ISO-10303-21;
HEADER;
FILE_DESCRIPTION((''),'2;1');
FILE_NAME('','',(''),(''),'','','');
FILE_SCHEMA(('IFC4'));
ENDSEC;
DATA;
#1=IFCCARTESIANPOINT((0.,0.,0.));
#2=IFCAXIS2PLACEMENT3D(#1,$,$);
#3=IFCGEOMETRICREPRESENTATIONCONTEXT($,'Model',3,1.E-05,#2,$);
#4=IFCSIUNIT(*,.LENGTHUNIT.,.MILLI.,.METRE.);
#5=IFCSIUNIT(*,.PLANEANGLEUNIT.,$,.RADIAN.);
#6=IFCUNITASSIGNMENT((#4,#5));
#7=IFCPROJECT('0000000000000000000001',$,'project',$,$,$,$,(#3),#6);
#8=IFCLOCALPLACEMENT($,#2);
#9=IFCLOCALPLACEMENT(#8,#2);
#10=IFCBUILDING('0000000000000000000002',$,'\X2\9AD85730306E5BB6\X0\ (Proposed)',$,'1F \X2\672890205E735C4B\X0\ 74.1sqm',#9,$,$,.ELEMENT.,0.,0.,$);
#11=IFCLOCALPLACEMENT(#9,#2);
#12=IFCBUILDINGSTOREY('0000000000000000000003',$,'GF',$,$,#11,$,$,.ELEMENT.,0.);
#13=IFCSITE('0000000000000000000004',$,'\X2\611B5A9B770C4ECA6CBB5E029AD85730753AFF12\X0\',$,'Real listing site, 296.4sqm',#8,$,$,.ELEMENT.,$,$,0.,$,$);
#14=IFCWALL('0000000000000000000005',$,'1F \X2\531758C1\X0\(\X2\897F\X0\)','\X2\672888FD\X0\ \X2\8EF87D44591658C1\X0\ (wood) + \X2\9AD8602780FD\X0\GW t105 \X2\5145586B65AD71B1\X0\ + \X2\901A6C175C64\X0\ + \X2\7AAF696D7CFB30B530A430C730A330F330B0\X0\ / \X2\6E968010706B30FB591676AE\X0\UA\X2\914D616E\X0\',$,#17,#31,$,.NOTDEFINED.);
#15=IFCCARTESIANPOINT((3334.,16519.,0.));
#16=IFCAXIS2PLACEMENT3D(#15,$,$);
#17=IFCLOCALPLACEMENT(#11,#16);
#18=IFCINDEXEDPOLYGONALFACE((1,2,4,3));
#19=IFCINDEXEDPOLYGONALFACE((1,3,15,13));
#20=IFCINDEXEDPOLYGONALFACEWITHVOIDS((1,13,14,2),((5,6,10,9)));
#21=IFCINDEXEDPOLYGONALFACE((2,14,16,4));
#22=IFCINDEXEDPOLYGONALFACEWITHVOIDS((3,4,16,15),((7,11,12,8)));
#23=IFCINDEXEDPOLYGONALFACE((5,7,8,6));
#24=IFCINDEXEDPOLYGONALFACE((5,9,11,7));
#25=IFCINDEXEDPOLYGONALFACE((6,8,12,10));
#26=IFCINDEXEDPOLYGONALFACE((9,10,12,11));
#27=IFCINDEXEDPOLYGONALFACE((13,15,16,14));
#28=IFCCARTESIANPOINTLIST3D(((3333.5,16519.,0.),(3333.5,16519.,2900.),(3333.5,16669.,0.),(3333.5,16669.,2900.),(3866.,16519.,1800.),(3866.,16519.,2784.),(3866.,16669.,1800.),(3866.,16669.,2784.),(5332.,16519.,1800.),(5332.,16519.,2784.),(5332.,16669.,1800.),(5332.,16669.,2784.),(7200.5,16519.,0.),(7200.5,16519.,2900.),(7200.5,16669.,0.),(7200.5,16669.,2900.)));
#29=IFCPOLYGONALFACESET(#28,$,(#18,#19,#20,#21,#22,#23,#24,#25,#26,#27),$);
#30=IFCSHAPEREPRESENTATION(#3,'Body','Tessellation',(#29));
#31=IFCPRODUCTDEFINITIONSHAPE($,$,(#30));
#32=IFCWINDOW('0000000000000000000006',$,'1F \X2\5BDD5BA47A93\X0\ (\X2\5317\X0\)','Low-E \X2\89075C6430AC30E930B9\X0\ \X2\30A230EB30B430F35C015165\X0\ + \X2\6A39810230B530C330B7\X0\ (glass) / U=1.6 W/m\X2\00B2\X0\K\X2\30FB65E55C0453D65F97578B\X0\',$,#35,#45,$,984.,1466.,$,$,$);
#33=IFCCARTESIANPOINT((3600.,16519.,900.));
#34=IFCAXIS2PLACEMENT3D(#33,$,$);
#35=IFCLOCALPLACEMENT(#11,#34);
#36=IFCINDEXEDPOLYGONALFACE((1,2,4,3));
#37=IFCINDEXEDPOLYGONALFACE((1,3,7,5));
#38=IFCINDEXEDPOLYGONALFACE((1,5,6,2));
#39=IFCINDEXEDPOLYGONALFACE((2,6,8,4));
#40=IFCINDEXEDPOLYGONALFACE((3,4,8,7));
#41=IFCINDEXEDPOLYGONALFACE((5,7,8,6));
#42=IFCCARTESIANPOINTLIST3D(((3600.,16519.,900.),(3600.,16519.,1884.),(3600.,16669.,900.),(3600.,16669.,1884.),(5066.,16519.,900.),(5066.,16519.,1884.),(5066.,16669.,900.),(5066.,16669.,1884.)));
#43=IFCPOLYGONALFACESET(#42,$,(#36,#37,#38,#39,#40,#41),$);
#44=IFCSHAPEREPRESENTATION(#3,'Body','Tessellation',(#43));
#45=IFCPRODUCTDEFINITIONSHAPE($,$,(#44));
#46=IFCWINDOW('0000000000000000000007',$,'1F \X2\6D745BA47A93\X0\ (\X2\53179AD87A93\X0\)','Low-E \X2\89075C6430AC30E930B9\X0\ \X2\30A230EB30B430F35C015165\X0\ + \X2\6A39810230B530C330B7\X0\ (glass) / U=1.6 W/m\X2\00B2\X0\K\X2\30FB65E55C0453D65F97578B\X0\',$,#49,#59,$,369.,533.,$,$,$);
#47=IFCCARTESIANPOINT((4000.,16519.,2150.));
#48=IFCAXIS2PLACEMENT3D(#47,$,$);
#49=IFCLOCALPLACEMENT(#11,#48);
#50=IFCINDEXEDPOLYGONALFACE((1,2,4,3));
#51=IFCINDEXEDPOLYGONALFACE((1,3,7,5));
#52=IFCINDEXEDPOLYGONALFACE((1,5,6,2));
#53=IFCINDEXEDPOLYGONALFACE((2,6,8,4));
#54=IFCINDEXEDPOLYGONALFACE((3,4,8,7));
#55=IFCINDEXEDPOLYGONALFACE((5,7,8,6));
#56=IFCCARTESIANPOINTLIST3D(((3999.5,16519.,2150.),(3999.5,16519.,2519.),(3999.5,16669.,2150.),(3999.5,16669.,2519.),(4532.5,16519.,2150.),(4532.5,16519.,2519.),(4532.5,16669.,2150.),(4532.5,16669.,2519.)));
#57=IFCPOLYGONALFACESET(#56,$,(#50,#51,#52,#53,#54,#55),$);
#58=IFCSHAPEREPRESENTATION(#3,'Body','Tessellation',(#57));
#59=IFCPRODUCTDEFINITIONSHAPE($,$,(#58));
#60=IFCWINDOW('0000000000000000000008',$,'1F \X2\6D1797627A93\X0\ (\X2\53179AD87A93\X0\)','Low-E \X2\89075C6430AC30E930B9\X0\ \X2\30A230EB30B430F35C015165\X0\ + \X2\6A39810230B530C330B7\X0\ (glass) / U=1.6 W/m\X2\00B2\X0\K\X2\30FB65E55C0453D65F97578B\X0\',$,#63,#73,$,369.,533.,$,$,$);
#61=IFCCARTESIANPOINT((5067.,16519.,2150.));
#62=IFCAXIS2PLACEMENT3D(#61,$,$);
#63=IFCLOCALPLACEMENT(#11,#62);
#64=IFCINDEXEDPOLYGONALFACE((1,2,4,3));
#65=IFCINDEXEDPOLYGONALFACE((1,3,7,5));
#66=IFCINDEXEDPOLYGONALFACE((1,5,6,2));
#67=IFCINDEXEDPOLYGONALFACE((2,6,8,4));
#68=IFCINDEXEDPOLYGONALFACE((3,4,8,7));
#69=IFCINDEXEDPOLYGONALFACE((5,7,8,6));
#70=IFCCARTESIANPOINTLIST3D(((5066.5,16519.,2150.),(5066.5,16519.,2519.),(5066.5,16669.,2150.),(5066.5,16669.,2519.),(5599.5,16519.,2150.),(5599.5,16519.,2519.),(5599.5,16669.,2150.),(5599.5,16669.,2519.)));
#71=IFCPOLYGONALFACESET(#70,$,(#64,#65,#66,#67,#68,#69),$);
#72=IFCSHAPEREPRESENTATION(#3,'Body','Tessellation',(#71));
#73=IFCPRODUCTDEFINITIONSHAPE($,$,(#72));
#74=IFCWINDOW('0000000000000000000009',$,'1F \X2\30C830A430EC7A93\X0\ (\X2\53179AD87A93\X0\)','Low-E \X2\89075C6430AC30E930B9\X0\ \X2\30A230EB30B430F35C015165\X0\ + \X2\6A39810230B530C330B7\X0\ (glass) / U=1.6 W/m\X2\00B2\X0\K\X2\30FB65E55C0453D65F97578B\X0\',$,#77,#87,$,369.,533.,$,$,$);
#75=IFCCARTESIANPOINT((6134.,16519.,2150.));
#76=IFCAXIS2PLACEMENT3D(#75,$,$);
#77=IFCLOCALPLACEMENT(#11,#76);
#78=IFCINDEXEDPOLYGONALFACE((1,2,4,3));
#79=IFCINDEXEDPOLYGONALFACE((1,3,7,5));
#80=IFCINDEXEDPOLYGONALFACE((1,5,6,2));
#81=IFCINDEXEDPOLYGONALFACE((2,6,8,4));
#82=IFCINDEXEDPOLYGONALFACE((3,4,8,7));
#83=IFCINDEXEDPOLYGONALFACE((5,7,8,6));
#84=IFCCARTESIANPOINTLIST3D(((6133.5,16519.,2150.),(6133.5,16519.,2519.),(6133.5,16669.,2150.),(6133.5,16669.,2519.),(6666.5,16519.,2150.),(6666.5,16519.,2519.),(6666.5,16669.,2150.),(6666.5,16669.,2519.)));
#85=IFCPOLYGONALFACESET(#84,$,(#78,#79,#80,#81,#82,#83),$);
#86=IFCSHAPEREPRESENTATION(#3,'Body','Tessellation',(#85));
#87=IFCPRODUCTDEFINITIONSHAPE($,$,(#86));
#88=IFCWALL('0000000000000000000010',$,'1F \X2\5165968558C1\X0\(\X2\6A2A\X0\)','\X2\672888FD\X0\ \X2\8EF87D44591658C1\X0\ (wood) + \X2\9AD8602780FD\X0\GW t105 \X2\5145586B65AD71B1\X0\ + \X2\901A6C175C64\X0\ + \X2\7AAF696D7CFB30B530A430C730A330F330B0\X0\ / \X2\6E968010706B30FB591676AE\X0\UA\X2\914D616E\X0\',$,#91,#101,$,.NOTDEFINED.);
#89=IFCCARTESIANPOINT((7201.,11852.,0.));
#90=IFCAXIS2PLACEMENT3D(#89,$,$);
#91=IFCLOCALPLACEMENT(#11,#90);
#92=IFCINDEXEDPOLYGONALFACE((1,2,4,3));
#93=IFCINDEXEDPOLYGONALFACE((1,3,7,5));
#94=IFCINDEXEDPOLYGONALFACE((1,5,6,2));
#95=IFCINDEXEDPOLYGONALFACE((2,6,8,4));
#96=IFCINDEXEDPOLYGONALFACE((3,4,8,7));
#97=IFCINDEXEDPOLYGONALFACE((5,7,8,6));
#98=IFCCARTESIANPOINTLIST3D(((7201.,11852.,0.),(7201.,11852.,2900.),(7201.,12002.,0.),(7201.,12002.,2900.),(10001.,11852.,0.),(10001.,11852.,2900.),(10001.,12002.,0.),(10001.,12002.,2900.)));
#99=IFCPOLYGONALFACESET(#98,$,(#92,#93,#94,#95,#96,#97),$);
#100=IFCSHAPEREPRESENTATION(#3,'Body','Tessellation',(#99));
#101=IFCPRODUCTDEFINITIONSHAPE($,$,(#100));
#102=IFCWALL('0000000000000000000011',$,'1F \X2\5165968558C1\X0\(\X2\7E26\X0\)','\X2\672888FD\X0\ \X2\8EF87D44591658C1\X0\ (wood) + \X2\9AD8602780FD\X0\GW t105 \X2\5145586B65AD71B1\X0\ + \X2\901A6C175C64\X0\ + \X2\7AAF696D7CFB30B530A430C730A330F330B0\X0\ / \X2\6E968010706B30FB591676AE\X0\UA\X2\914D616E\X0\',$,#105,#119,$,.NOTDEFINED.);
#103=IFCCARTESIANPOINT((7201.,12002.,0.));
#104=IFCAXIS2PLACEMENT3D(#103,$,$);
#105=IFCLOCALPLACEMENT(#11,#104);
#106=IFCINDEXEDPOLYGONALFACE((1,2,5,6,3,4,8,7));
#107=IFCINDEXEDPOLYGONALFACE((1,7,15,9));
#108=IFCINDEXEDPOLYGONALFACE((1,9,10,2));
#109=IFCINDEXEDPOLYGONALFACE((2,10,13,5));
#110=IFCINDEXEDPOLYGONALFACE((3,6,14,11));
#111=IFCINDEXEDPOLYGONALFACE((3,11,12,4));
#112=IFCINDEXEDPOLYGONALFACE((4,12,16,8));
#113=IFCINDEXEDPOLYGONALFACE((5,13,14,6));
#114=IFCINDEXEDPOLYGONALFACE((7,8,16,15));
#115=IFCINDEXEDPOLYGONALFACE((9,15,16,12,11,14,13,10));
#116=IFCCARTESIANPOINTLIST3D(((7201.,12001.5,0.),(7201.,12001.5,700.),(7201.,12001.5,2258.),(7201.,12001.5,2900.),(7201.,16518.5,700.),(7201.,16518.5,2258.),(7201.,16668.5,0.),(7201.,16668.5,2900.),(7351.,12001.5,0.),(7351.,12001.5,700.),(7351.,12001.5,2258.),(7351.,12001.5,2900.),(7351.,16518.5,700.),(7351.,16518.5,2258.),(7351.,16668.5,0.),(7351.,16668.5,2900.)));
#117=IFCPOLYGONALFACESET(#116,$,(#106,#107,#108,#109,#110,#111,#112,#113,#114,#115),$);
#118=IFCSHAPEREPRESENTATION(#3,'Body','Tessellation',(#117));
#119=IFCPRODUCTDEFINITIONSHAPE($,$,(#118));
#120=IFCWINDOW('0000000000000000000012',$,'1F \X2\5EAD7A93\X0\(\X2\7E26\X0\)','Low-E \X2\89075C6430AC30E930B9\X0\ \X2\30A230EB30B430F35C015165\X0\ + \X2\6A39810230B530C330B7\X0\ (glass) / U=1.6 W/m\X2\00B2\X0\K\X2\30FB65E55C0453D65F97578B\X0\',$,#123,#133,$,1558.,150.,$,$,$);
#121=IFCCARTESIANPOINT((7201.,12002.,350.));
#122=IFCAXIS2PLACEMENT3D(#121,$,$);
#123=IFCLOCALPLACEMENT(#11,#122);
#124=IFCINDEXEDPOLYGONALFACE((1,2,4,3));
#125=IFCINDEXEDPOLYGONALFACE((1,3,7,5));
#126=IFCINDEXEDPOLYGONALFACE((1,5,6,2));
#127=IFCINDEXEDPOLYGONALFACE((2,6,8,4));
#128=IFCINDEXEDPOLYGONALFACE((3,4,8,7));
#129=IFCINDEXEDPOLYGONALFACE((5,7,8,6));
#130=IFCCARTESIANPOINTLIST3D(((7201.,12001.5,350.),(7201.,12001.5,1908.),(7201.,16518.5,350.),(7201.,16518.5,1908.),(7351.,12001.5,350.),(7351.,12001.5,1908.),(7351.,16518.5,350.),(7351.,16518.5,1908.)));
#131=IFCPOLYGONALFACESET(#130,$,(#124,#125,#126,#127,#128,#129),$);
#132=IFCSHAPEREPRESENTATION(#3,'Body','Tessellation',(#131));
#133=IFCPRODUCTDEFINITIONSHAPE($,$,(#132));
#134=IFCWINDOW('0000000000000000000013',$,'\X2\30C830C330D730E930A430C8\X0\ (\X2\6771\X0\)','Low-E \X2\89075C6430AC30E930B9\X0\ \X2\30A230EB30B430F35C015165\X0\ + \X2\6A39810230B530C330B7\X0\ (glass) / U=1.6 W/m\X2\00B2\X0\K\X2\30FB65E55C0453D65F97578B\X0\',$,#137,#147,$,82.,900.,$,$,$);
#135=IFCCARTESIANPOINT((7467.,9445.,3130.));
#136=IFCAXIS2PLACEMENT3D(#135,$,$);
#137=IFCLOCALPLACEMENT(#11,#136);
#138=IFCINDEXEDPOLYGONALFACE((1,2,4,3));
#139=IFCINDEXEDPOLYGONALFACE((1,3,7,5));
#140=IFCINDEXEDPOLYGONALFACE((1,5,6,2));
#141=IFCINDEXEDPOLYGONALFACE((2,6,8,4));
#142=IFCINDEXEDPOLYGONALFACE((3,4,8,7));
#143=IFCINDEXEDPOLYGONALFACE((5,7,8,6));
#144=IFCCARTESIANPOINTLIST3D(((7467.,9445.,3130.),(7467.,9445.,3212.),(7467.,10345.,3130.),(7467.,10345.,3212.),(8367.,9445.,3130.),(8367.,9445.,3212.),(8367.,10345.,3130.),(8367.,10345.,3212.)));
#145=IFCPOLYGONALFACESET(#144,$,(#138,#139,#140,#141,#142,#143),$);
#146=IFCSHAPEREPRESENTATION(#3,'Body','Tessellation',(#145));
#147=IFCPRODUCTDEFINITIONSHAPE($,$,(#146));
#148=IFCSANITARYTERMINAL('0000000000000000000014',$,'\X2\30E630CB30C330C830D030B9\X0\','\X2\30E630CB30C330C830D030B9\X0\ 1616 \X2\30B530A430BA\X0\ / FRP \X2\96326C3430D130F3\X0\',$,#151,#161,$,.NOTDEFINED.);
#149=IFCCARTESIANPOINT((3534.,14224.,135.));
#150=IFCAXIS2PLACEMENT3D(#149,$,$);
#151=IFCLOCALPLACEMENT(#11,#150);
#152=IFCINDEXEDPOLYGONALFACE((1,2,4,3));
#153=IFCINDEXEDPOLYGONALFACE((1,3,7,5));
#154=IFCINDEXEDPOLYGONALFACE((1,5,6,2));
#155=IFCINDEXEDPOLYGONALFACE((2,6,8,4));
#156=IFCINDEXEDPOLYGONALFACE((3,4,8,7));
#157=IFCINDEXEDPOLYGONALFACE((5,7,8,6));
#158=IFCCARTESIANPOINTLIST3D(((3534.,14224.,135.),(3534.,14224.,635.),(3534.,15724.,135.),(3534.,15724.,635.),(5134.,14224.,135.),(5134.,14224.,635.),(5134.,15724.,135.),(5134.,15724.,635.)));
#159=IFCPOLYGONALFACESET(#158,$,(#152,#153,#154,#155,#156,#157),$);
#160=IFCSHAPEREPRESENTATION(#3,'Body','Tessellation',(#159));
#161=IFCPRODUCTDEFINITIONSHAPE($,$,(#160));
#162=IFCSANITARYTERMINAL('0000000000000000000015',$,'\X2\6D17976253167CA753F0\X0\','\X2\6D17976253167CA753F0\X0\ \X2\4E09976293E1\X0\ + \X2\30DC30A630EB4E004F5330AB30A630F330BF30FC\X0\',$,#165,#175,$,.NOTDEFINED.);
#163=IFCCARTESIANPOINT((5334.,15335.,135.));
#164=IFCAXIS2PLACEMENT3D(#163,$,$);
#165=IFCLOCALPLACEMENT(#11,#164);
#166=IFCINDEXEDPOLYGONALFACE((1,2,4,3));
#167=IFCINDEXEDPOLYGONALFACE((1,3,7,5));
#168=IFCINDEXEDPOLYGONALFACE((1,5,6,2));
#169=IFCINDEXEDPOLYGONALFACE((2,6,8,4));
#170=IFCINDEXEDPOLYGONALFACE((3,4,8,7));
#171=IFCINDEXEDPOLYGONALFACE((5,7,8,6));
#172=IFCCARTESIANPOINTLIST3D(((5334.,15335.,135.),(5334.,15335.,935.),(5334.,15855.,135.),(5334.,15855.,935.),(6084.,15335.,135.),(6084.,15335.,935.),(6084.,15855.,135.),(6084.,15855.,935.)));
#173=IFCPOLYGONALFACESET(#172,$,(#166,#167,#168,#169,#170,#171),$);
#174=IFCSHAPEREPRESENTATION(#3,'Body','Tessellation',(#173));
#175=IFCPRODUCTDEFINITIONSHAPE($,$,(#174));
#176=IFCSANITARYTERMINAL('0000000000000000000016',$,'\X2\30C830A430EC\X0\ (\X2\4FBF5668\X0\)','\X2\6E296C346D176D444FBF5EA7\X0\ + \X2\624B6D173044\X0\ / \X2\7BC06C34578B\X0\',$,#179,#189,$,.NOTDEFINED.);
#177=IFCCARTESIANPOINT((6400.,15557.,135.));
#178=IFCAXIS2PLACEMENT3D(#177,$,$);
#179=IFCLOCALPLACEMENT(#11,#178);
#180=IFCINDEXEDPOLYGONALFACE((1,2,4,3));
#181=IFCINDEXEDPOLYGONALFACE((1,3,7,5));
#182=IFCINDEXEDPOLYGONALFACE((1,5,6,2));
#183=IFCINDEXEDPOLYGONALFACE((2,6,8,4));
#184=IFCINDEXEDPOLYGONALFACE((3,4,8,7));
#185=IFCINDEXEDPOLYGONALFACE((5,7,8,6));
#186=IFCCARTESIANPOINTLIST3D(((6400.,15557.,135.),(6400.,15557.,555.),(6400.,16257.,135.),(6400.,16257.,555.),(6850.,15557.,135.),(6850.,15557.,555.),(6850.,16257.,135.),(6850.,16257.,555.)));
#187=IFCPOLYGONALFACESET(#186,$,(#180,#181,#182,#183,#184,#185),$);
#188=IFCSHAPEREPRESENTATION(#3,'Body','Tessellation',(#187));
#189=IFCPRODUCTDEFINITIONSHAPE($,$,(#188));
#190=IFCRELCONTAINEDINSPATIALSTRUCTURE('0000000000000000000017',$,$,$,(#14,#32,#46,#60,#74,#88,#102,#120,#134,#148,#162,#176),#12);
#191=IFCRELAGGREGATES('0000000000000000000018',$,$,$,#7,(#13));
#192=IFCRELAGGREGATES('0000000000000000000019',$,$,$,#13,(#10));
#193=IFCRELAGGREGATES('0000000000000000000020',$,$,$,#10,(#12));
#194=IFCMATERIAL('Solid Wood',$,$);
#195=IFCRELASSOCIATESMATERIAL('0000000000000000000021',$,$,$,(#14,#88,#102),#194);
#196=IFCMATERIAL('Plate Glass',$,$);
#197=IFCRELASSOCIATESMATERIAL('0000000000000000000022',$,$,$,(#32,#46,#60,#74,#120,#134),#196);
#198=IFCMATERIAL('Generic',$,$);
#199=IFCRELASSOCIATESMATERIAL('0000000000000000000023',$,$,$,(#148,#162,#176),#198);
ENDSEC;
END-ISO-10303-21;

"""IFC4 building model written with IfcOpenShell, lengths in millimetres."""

from ifc_helpers import new_model, si_unit, frame, frame_2d, origin, place, context, project, spatial, rectangle, extrude, material, element, fill, save


model = new_model("IFC4")

# Units and contexts
model_context = context("Model", 3, precision=1e-05, world=origin())
ifc_project = project(units=[si_unit("LENGTHUNIT", "METRE", prefix="MILLI"), si_unit("PLANEANGLEUNIT", "RADIAN")], contexts=[model_context])

# Site, building, storey
site_placement = place(None, origin())
site = spatial("IfcSite", under=ifc_project, at=site_placement, Name="愛媛県今治市高地町２", ObjectType="Real listing site, 296.4sqm", CompositionType="ELEMENT", RefElevation=0.0)
building_placement = place(site_placement, origin())
building = spatial("IfcBuilding", under=site, at=building_placement, Name="高地の家 (Proposed)", ObjectType="1F 木造平屋 74.1sqm", CompositionType="ELEMENT", ElevationOfRefHeight=0.0, ElevationOfTerrain=0.0)
storey_placement = place(building_placement, origin())
storey = spatial("IfcBuildingStorey", under=building, at=storey_placement, Name="GF", CompositionType="ELEMENT", Elevation=0.0)

# Shared definitions
ifc_material_1 = material(Name="Solid Wood")

# Wall, openings, windows
wall_1_placement = place(storey_placement, frame((3334.0, 16519.0, 0.0)))
wall_1 = element("IfcWall", 1, at=wall_1_placement, inside=storey, material=ifc_material_1, Name="1F 北壁(西)", Description="木製 軸組外壁 (wood) + 高性能GW t105 充填断熱 + 通気層 + 窯業系サイディング / 準耐火・外皮UA配慮", PredefinedType="NOTDEFINED", context=model_context, shape_type="SweptSolid", body=[
    extrude(rectangle(XDim=3867.0, YDim=150.0, at=frame_2d((1933.0, 75.0))), frame((3334.0, 16519.0, 0.0)), (0.0, 0.0, 1.0), 2900.0),
])
opening_1_placement = place(storey_placement, frame((3600.0, 16519.0, 900.0)))
opening_1 = element("IfcOpeningElement", 2, at=opening_1_placement, cuts=wall_1, PredefinedType="NOTDEFINED", context=model_context, shape_type="SweptSolid", body=[
    extrude(rectangle(XDim=1466.0, YDim=150.0, at=frame_2d((733.0, 75.0))), frame((3600.0, 16519.0, 900.0)), (0.0, 0.0, 1.0), 984.0),
])
opening_2_placement = place(storey_placement, frame((4000.0, 16519.0, 2150.0)))
opening_2 = element("IfcOpeningElement", 3, at=opening_2_placement, cuts=wall_1, PredefinedType="NOTDEFINED", context=model_context, shape_type="SweptSolid", body=[
    extrude(rectangle(XDim=533.0, YDim=150.0, at=frame_2d((266.0, 75.0))), frame((4000.0, 16519.0, 2150.0)), (0.0, 0.0, 1.0), 369.0),
])
opening_3_placement = place(storey_placement, frame((5067.0, 16519.0, 2150.0)))
opening_3 = element("IfcOpeningElement", 4, at=opening_3_placement, cuts=wall_1, PredefinedType="NOTDEFINED", context=model_context, shape_type="SweptSolid", body=[
    extrude(rectangle(XDim=533.0, YDim=150.0, at=frame_2d((266.0, 75.0))), frame((5067.0, 16519.0, 2150.0)), (0.0, 0.0, 1.0), 369.0),
])
opening_4_placement = place(storey_placement, frame((6134.0, 16519.0, 2150.0)))
opening_4 = element("IfcOpeningElement", 5, at=opening_4_placement, cuts=wall_1, PredefinedType="NOTDEFINED", context=model_context, shape_type="SweptSolid", body=[
    extrude(rectangle(XDim=533.0, YDim=150.0, at=frame_2d((266.0, 75.0))), frame((6134.0, 16519.0, 2150.0)), (0.0, 0.0, 1.0), 369.0),
])
ifc_material_2 = material(Name="Plate Glass")
window_1_placement = place(storey_placement, frame((3600.0, 16519.0, 900.0)))
window_1 = element("IfcWindow", 6, at=window_1_placement, inside=storey, material=ifc_material_2, Name="1F 寝室窓 (北)", Description="Low-E 複層ガラス アルゴン封入 + 樹脂サッシ (glass) / U=1.6 W/m²K・日射取得型", OverallHeight=984.0, OverallWidth=1466.0, context=model_context, shape_type="SweptSolid", body=[
    extrude(rectangle(XDim=1466.0, YDim=150.0, at=frame_2d((733.0, 75.0))), frame((3600.0, 16519.0, 900.0)), (0.0, 0.0, 1.0), 984.0),
])
fill(opening_1, window_1)
window_2_placement = place(storey_placement, frame((4000.0, 16519.0, 2150.0)))
window_2 = element("IfcWindow", 7, at=window_2_placement, inside=storey, material=ifc_material_2, Name="1F 浴室窓 (北高窓)", Description="Low-E 複層ガラス アルゴン封入 + 樹脂サッシ (glass) / U=1.6 W/m²K・日射取得型", OverallHeight=369.0, OverallWidth=533.0, context=model_context, shape_type="SweptSolid", body=[
    extrude(rectangle(XDim=533.0, YDim=150.0, at=frame_2d((266.0, 75.0))), frame((4000.0, 16519.0, 2150.0)), (0.0, 0.0, 1.0), 369.0),
])
fill(opening_2, window_2)
window_3_placement = place(storey_placement, frame((5067.0, 16519.0, 2150.0)))
window_3 = element("IfcWindow", 8, at=window_3_placement, inside=storey, material=ifc_material_2, Name="1F 洗面窓 (北高窓)", Description="Low-E 複層ガラス アルゴン封入 + 樹脂サッシ (glass) / U=1.6 W/m²K・日射取得型", OverallHeight=369.0, OverallWidth=533.0, context=model_context, shape_type="SweptSolid", body=[
    extrude(rectangle(XDim=533.0, YDim=150.0, at=frame_2d((266.0, 75.0))), frame((5067.0, 16519.0, 2150.0)), (0.0, 0.0, 1.0), 369.0),
])
fill(opening_3, window_3)
window_4_placement = place(storey_placement, frame((6134.0, 16519.0, 2150.0)))
window_4 = element("IfcWindow", 9, at=window_4_placement, inside=storey, material=ifc_material_2, Name="1F トイレ窓 (北高窓)", Description="Low-E 複層ガラス アルゴン封入 + 樹脂サッシ (glass) / U=1.6 W/m²K・日射取得型", OverallHeight=369.0, OverallWidth=533.0, context=model_context, shape_type="SweptSolid", body=[
    extrude(rectangle(XDim=533.0, YDim=150.0, at=frame_2d((266.0, 75.0))), frame((6134.0, 16519.0, 2150.0)), (0.0, 0.0, 1.0), 369.0),
])
fill(opening_4, window_4)

# Wall
wall_2_placement = place(storey_placement, frame((7201.0, 11852.0, 0.0)))
element("IfcWall", 10, at=wall_2_placement, inside=storey, material=ifc_material_1, Name="1F 入隅壁(横)", Description="木製 軸組外壁 (wood) + 高性能GW t105 充填断熱 + 通気層 + 窯業系サイディング / 準耐火・外皮UA配慮", PredefinedType="NOTDEFINED", context=model_context, shape_type="SweptSolid", body=[
    extrude(rectangle(XDim=2800.0, YDim=150.0, at=frame_2d((1400.0, 75.0))), frame((7201.0, 11852.0, 0.0)), (0.0, 0.0, 1.0), 2900.0),
])

# Wall, opening, window
wall_3_placement = place(storey_placement, frame((7201.0, 12002.0, 0.0)))
wall_3 = element("IfcWall", 11, at=wall_3_placement, inside=storey, material=ifc_material_1, Name="1F 入隅壁(縦)", Description="木製 軸組外壁 (wood) + 高性能GW t105 充填断熱 + 通気層 + 窯業系サイディング / 準耐火・外皮UA配慮", PredefinedType="NOTDEFINED", context=model_context, shape_type="SweptSolid", body=[
    extrude(rectangle(XDim=150.0, YDim=4667.0, at=frame_2d((75.0, 2333.0))), frame((7201.0, 12002.0, 0.0)), (0.0, 0.0, 1.0), 2900.0),
])
opening_5_placement = place(storey_placement, frame((7201.0, 12002.0, 350.0)))
opening_5 = element("IfcOpeningElement", 12, at=opening_5_placement, cuts=wall_3, PredefinedType="NOTDEFINED", context=model_context, shape_type="SweptSolid", body=[
    extrude(rectangle(XDim=150.0, YDim=4517.0, at=frame_2d((75.0, 2258.0))), frame((7201.0, 12002.0, 350.0)), (0.0, 0.0, 1.0), 1558.0),
])
window_5_placement = place(storey_placement, frame((7201.0, 12002.0, 350.0)))
window_5 = element("IfcWindow", 13, at=window_5_placement, inside=storey, material=ifc_material_2, Name="1F 庭窓(縦)", Description="Low-E 複層ガラス アルゴン封入 + 樹脂サッシ (glass) / U=1.6 W/m²K・日射取得型", OverallHeight=1558.0, OverallWidth=150.0, context=model_context, shape_type="SweptSolid", body=[
    extrude(rectangle(XDim=150.0, YDim=4517.0, at=frame_2d((75.0, 2258.0))), frame((7201.0, 12002.0, 350.0)), (0.0, 0.0, 1.0), 1558.0),
])
fill(opening_5, window_5)

# Window
window_6_placement = place(storey_placement, frame((7467.0, 9445.0, 3130.0)))
element("IfcWindow", 14, at=window_6_placement, inside=storey, material=ifc_material_2, Name="トップライト (東)", Description="Low-E 複層ガラス アルゴン封入 + 樹脂サッシ (glass) / U=1.6 W/m²K・日射取得型", OverallHeight=82.0, OverallWidth=900.0, context=model_context, shape_type="SweptSolid", body=[
    extrude(rectangle(XDim=900.0, YDim=900.0, at=frame_2d((450.0, 450.0))), frame((7467.0, 9445.0, 3130.0)), (0.0, 0.0, 1.0), 82.0),
])

# Shared definitions
ifc_material_3 = material(Name="Generic")

# Sanitary terminals
sanitary_terminal_1_placement = place(storey_placement, frame((3534.0, 14224.0, 135.0)))
element("IfcSanitaryTerminal", 15, at=sanitary_terminal_1_placement, inside=storey, material=ifc_material_3, Name="ユニットバス", Description="ユニットバス 1616 サイズ / FRP 防水パン", PredefinedType="NOTDEFINED", context=model_context, shape_type="SweptSolid", body=[
    extrude(rectangle(XDim=1600.0, YDim=1500.0, at=frame_2d((800.0, 750.0))), frame((3534.0, 14224.0, 135.0)), (0.0, 0.0, 1.0), 500.0),
])
sanitary_terminal_2_placement = place(storey_placement, frame((5334.0, 15335.0, 135.0)))
element("IfcSanitaryTerminal", 16, at=sanitary_terminal_2_placement, inside=storey, material=ifc_material_3, Name="洗面化粧台", Description="洗面化粧台 三面鏡 + ボウル一体カウンター", PredefinedType="NOTDEFINED", context=model_context, shape_type="SweptSolid", body=[
    extrude(rectangle(XDim=750.0, YDim=520.0, at=frame_2d((375.0, 260.0))), frame((5334.0, 15335.0, 135.0)), (0.0, 0.0, 1.0), 800.0),
])
sanitary_terminal_3_placement = place(storey_placement, frame((6400.0, 15557.0, 135.0)))
element("IfcSanitaryTerminal", 17, at=sanitary_terminal_3_placement, inside=storey, material=ifc_material_3, Name="トイレ (便器)", Description="温水洗浄便座 + 手洗い / 節水型", PredefinedType="NOTDEFINED", context=model_context, shape_type="SweptSolid", body=[
    extrude(rectangle(XDim=450.0, YDim=700.0, at=frame_2d((225.0, 350.0))), frame((6400.0, 15557.0, 135.0)), (0.0, 0.0, 1.0), 420.0),
])

save(model, "model.ifc")
